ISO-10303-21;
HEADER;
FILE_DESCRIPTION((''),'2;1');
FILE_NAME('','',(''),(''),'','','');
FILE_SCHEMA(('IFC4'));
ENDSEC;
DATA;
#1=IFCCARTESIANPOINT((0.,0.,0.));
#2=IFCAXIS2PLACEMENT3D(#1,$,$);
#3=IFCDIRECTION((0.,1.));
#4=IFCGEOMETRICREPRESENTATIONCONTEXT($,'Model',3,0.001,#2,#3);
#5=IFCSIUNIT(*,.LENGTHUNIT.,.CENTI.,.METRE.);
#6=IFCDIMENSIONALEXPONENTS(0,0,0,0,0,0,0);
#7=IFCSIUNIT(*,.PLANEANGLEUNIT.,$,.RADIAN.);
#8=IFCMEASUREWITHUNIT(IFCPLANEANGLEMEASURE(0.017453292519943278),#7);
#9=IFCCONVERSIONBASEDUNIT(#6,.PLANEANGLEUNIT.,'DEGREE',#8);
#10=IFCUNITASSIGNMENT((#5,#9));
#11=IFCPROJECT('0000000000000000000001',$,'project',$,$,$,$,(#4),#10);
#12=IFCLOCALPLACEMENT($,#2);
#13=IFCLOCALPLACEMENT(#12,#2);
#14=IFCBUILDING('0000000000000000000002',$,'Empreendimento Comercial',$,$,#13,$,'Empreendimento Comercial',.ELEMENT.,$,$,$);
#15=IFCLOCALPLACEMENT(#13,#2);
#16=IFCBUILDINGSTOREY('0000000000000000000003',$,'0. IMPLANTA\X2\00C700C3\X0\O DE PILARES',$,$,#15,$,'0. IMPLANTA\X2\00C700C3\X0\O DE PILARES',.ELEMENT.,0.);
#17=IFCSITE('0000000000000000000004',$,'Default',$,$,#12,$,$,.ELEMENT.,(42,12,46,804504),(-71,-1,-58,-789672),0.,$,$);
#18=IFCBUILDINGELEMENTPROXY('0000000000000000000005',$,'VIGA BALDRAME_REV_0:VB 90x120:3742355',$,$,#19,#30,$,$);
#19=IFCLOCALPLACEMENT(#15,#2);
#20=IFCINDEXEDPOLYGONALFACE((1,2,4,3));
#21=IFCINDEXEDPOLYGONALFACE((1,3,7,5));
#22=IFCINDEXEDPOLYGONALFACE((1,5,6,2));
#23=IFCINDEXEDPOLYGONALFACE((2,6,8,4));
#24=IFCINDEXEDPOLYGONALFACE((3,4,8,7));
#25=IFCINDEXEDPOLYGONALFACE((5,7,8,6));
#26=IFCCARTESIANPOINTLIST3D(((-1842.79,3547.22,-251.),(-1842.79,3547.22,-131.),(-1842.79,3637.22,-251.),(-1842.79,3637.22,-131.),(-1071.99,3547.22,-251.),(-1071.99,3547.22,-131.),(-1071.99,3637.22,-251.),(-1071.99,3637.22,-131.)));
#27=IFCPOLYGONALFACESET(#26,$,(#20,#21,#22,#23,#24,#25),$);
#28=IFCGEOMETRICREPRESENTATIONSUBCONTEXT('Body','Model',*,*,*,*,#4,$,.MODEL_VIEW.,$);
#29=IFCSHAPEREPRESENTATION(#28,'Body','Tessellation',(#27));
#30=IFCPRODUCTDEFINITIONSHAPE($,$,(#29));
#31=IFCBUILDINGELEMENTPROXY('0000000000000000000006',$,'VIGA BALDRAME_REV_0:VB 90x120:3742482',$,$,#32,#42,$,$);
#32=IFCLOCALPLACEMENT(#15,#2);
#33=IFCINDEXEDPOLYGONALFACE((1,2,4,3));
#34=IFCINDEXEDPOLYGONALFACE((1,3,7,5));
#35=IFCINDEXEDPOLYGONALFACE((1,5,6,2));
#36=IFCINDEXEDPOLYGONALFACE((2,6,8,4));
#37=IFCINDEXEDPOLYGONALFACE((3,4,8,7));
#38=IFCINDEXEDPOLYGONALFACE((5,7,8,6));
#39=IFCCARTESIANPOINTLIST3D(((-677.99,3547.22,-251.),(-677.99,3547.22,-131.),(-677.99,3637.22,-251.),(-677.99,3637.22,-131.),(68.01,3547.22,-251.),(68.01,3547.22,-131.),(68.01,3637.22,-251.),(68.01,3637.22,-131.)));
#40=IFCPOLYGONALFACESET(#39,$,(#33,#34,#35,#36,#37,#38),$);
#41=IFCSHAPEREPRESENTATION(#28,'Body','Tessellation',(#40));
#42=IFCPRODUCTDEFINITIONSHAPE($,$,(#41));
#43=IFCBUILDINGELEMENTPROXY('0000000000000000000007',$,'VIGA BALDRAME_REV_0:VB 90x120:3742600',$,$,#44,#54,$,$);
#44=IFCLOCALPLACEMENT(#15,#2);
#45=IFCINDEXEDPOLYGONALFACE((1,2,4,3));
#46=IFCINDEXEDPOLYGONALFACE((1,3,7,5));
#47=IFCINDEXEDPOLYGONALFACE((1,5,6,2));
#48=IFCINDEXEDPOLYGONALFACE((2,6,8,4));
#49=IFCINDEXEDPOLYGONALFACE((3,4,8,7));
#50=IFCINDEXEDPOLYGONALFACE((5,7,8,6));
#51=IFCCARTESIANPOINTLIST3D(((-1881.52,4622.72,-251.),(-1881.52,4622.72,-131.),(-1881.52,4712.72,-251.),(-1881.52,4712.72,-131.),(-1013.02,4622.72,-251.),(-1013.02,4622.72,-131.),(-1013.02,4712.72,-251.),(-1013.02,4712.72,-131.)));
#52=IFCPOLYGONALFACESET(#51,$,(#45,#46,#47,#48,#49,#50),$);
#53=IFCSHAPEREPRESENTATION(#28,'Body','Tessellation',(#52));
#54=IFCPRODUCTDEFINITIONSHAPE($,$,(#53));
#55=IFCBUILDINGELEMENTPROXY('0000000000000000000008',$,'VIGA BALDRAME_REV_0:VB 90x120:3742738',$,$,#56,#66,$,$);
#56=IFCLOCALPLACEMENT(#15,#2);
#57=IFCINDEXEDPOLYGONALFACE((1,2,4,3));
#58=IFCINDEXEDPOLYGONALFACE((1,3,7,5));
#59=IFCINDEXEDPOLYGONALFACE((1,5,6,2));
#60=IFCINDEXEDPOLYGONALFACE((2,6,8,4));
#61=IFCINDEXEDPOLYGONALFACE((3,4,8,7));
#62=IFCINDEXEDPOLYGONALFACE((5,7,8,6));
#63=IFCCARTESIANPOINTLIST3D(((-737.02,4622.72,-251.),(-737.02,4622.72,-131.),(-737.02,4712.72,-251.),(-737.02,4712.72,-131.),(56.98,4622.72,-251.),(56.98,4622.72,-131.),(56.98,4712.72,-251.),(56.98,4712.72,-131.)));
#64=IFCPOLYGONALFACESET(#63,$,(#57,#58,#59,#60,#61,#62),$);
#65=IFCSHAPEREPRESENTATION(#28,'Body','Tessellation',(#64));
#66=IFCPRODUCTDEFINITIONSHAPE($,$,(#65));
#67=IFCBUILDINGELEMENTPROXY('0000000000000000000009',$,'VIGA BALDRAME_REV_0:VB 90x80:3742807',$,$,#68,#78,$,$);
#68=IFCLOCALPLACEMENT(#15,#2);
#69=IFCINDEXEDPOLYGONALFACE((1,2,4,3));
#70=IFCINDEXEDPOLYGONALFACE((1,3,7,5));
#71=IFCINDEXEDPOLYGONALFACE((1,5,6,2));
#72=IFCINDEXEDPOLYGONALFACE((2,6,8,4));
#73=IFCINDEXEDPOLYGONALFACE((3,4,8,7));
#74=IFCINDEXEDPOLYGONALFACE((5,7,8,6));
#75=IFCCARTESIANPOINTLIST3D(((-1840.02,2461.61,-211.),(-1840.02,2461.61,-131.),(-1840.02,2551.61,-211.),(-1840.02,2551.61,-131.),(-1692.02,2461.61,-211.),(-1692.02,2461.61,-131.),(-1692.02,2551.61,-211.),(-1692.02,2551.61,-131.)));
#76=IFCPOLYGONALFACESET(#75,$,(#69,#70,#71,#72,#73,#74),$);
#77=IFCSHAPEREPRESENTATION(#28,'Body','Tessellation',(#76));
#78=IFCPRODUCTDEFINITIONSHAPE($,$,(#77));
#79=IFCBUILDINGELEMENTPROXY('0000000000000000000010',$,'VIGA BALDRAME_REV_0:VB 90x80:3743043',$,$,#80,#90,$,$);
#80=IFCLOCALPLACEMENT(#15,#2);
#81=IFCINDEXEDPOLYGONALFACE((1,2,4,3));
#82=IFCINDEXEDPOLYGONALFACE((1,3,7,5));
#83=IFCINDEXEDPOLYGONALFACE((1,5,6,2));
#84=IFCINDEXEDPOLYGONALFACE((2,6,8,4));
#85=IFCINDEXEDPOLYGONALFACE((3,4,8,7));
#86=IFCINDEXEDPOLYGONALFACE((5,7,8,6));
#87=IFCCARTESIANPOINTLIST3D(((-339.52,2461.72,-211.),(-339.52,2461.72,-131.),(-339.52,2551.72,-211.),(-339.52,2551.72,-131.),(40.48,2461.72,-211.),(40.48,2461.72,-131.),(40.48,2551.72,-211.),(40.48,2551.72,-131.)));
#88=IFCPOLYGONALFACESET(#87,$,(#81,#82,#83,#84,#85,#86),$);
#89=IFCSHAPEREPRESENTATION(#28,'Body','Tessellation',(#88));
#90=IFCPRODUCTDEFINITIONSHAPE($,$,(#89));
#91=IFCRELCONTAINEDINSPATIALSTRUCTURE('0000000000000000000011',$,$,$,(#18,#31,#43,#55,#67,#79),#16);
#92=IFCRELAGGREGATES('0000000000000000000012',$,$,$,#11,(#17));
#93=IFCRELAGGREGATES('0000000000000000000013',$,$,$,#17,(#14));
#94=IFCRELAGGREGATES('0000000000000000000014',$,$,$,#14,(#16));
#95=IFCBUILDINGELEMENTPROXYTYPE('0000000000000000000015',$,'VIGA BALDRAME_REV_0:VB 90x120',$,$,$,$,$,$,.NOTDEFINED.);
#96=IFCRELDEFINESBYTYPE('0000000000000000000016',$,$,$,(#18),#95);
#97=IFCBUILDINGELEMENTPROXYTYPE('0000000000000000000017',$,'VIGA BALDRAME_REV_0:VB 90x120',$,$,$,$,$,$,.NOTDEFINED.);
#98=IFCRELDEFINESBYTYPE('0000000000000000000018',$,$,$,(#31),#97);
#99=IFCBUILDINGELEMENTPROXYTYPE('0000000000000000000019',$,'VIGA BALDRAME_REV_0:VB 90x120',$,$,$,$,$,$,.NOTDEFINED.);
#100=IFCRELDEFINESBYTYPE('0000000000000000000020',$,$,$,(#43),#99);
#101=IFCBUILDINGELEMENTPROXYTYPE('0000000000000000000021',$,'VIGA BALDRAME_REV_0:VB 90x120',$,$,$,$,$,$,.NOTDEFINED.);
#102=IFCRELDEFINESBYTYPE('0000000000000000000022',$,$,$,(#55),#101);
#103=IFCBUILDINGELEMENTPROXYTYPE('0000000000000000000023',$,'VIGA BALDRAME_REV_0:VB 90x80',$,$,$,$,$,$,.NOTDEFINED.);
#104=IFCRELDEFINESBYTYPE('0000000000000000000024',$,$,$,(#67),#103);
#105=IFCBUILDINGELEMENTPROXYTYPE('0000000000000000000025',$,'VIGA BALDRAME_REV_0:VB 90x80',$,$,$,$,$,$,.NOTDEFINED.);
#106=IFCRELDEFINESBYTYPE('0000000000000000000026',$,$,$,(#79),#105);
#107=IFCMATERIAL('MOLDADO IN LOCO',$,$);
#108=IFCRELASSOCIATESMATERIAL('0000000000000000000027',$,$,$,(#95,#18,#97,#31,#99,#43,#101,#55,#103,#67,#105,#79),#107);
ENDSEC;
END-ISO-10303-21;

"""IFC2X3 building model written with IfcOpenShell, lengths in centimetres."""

from ifc_helpers import new_model, entity, si_unit, converted_unit, direction, frame, frame_2d, origin, origin_2d_with_axis, place, context, subcontext, project, spatial, rectangle, extrude, source, transform, mapped, material, type_object, type_shapes, element, save


model = new_model("IFC2X3")

# Units and contexts
model_context = context("Model", 3, precision=0.001, world=origin(), true_north=direction((0.0, 1.0)))
body_context = subcontext(model_context, "Body", "Model", "MODEL_VIEW")
ifc_project = project(units=[si_unit("LENGTHUNIT", "METRE", prefix="CENTI"), converted_unit("PLANEANGLEUNIT", "DEGREE", entity("IfcPlaneAngleMeasure", 0.017453292519943278), si_unit("PLANEANGLEUNIT", "RADIAN"), dimensions=[0, 0, 0, 0, 0, 0, 0])], contexts=[model_context])

# Site, building, storey
site_placement = place(None, origin())
site = spatial("IfcSite", under=ifc_project, at=site_placement, Name="Default", CompositionType="ELEMENT", RefLatitude=(42, 12, 46, 804504), RefLongitude=(-71, -1, -58, -789672), RefElevation=0.0)
building_placement = place(site_placement, origin())
building = spatial("IfcBuilding", under=site, at=building_placement, Name="Empreendimento Comercial", LongName="Empreendimento Comercial", CompositionType="ELEMENT")
storey_placement = place(building_placement, origin())
storey = spatial("IfcBuildingStorey", under=building, at=storey_placement, Name="0. IMPLANTAÇÃO DE PILARES", LongName="0. IMPLANTAÇÃO DE PILARES", CompositionType="ELEMENT", Elevation=0.0)

# Shared definitions
ifc_material_1 = material(Name="MOLDADO IN LOCO")

# Building element proxies
building_element_proxy_type_1 = type_object("IfcBuildingElementProxyType", Name="VIGA BALDRAME_REV_0:VB 90x120", PredefinedType="NOTDEFINED", material=ifc_material_1)
shared_shape_1 = source(origin(), body_context, "Body", "SweptSolid", [
    extrude(rectangle(XDim=770.8, YDim=90.0, at=frame_2d((0.0, 0.0), x_axis=(1.0, 0.0))), frame((-1457.39, 3592.22, -251.0), z_axis=(0.0, 0.0, 1.0), x_axis=(-1.0, 0.0, 0.0)), (0.0, 0.0, 1.0), 120.0),
])
type_shapes(building_element_proxy_type_1, [shared_shape_1])
proxy_1_placement = place(storey_placement, origin())
element("IfcBuildingElementProxy", 1, at=proxy_1_placement, inside=storey, type_object=building_element_proxy_type_1, material=ifc_material_1, Name="VIGA BALDRAME_REV_0:VB 90x120:3742355", context=body_context, shape_type="MappedRepresentation", body=[
    mapped(shared_shape_1, transform((0.0, 0.0, 0.0), scale=1.0)),
])
building_element_proxy_type_2 = type_object("IfcBuildingElementProxyType", Name="VIGA BALDRAME_REV_0:VB 90x120", PredefinedType="NOTDEFINED", material=ifc_material_1)
shared_shape_2 = source(origin(), body_context, "Body", "SweptSolid", [
    extrude(rectangle(XDim=90.0, YDim=746.0, at=origin_2d_with_axis()), frame((-304.99, 3592.22, -251.0), z_axis=(0.0, 0.0, 1.0), x_axis=(0.0, -1.0, 0.0)), (0.0, 0.0, 1.0), 120.0),
])
type_shapes(building_element_proxy_type_2, [shared_shape_2])
proxy_2_placement = place(storey_placement, origin())
element("IfcBuildingElementProxy", 2, at=proxy_2_placement, inside=storey, type_object=building_element_proxy_type_2, material=ifc_material_1, Name="VIGA BALDRAME_REV_0:VB 90x120:3742482", context=body_context, shape_type="MappedRepresentation", body=[
    mapped(shared_shape_2, transform((0.0, 0.0, 0.0), scale=1.0)),
])
building_element_proxy_type_3 = type_object("IfcBuildingElementProxyType", Name="VIGA BALDRAME_REV_0:VB 90x120", PredefinedType="NOTDEFINED", material=ifc_material_1)
shared_shape_3 = source(origin(), body_context, "Body", "SweptSolid", [
    extrude(rectangle(XDim=868.5, YDim=90.0, at=frame_2d((0.0, 0.0), x_axis=(1.0, 0.0))), frame((-1447.27, 4667.72, -251.0), z_axis=(0.0, 0.0, 1.0), x_axis=(-1.0, 0.0, 0.0)), (0.0, 0.0, 1.0), 120.0),
])
type_shapes(building_element_proxy_type_3, [shared_shape_3])
proxy_3_placement = place(storey_placement, origin())
element("IfcBuildingElementProxy", 3, at=proxy_3_placement, inside=storey, type_object=building_element_proxy_type_3, material=ifc_material_1, Name="VIGA BALDRAME_REV_0:VB 90x120:3742600", context=body_context, shape_type="MappedRepresentation", body=[
    mapped(shared_shape_3, transform((0.0, 0.0, 0.0), scale=1.0)),
])
building_element_proxy_type_4 = type_object("IfcBuildingElementProxyType", Name="VIGA BALDRAME_REV_0:VB 90x120", PredefinedType="NOTDEFINED", material=ifc_material_1)
shared_shape_4 = source(origin(), body_context, "Body", "SweptSolid", [
    extrude(rectangle(XDim=90.0, YDim=794.0, at=frame_2d((0.0, 0.0), x_axis=(1.0, 0.0))), frame((-340.02, 4667.72, -251.0), z_axis=(0.0, 0.0, 1.0), x_axis=(0.0, -1.0, 0.0)), (0.0, 0.0, 1.0), 120.0),
])
type_shapes(building_element_proxy_type_4, [shared_shape_4])
proxy_4_placement = place(storey_placement, origin())
element("IfcBuildingElementProxy", 4, at=proxy_4_placement, inside=storey, type_object=building_element_proxy_type_4, material=ifc_material_1, Name="VIGA BALDRAME_REV_0:VB 90x120:3742738", context=body_context, shape_type="MappedRepresentation", body=[
    mapped(shared_shape_4, transform((0.0, 0.0, 0.0), scale=1.0)),
])
building_element_proxy_type_5 = type_object("IfcBuildingElementProxyType", Name="VIGA BALDRAME_REV_0:VB 90x80", PredefinedType="NOTDEFINED", material=ifc_material_1)
shared_shape_5 = source(origin(), body_context, "Body", "SweptSolid", [
    extrude(rectangle(XDim=148.0, YDim=90.0, at=frame_2d((0.0, 0.0), x_axis=(1.0, 0.0))), frame((-1766.02, 2506.61, -211.0), z_axis=(0.0, 0.0, 1.0), x_axis=(-1.0, 0.0, 0.0)), (0.0, 0.0, 1.0), 80.0),
])
type_shapes(building_element_proxy_type_5, [shared_shape_5])
proxy_5_placement = place(storey_placement, origin())
element("IfcBuildingElementProxy", 5, at=proxy_5_placement, inside=storey, type_object=building_element_proxy_type_5, material=ifc_material_1, Name="VIGA BALDRAME_REV_0:VB 90x80:3742807", context=body_context, shape_type="MappedRepresentation", body=[
    mapped(shared_shape_5, transform((0.0, 0.0, 0.0), scale=1.0)),
])
building_element_proxy_type_6 = type_object("IfcBuildingElementProxyType", Name="VIGA BALDRAME_REV_0:VB 90x80", PredefinedType="NOTDEFINED", material=ifc_material_1)
shared_shape_6 = source(origin(), body_context, "Body", "SweptSolid", [
    extrude(rectangle(XDim=90.0, YDim=380.0, at=frame_2d((0.0, 0.0), x_axis=(1.0, 0.0))), frame((-149.52, 2506.72, -211.0), z_axis=(0.0, 0.0, 1.0), x_axis=(0.0, -1.0, 0.0)), (0.0, 0.0, 1.0), 80.0),
])
type_shapes(building_element_proxy_type_6, [shared_shape_6])
proxy_6_placement = place(storey_placement, origin())
element("IfcBuildingElementProxy", 6, at=proxy_6_placement, inside=storey, type_object=building_element_proxy_type_6, material=ifc_material_1, Name="VIGA BALDRAME_REV_0:VB 90x80:3743043", context=body_context, shape_type="MappedRepresentation", body=[
    mapped(shared_shape_6, transform((0.0, 0.0, 0.0), scale=1.0)),
])

save(model, "model.ifc")
